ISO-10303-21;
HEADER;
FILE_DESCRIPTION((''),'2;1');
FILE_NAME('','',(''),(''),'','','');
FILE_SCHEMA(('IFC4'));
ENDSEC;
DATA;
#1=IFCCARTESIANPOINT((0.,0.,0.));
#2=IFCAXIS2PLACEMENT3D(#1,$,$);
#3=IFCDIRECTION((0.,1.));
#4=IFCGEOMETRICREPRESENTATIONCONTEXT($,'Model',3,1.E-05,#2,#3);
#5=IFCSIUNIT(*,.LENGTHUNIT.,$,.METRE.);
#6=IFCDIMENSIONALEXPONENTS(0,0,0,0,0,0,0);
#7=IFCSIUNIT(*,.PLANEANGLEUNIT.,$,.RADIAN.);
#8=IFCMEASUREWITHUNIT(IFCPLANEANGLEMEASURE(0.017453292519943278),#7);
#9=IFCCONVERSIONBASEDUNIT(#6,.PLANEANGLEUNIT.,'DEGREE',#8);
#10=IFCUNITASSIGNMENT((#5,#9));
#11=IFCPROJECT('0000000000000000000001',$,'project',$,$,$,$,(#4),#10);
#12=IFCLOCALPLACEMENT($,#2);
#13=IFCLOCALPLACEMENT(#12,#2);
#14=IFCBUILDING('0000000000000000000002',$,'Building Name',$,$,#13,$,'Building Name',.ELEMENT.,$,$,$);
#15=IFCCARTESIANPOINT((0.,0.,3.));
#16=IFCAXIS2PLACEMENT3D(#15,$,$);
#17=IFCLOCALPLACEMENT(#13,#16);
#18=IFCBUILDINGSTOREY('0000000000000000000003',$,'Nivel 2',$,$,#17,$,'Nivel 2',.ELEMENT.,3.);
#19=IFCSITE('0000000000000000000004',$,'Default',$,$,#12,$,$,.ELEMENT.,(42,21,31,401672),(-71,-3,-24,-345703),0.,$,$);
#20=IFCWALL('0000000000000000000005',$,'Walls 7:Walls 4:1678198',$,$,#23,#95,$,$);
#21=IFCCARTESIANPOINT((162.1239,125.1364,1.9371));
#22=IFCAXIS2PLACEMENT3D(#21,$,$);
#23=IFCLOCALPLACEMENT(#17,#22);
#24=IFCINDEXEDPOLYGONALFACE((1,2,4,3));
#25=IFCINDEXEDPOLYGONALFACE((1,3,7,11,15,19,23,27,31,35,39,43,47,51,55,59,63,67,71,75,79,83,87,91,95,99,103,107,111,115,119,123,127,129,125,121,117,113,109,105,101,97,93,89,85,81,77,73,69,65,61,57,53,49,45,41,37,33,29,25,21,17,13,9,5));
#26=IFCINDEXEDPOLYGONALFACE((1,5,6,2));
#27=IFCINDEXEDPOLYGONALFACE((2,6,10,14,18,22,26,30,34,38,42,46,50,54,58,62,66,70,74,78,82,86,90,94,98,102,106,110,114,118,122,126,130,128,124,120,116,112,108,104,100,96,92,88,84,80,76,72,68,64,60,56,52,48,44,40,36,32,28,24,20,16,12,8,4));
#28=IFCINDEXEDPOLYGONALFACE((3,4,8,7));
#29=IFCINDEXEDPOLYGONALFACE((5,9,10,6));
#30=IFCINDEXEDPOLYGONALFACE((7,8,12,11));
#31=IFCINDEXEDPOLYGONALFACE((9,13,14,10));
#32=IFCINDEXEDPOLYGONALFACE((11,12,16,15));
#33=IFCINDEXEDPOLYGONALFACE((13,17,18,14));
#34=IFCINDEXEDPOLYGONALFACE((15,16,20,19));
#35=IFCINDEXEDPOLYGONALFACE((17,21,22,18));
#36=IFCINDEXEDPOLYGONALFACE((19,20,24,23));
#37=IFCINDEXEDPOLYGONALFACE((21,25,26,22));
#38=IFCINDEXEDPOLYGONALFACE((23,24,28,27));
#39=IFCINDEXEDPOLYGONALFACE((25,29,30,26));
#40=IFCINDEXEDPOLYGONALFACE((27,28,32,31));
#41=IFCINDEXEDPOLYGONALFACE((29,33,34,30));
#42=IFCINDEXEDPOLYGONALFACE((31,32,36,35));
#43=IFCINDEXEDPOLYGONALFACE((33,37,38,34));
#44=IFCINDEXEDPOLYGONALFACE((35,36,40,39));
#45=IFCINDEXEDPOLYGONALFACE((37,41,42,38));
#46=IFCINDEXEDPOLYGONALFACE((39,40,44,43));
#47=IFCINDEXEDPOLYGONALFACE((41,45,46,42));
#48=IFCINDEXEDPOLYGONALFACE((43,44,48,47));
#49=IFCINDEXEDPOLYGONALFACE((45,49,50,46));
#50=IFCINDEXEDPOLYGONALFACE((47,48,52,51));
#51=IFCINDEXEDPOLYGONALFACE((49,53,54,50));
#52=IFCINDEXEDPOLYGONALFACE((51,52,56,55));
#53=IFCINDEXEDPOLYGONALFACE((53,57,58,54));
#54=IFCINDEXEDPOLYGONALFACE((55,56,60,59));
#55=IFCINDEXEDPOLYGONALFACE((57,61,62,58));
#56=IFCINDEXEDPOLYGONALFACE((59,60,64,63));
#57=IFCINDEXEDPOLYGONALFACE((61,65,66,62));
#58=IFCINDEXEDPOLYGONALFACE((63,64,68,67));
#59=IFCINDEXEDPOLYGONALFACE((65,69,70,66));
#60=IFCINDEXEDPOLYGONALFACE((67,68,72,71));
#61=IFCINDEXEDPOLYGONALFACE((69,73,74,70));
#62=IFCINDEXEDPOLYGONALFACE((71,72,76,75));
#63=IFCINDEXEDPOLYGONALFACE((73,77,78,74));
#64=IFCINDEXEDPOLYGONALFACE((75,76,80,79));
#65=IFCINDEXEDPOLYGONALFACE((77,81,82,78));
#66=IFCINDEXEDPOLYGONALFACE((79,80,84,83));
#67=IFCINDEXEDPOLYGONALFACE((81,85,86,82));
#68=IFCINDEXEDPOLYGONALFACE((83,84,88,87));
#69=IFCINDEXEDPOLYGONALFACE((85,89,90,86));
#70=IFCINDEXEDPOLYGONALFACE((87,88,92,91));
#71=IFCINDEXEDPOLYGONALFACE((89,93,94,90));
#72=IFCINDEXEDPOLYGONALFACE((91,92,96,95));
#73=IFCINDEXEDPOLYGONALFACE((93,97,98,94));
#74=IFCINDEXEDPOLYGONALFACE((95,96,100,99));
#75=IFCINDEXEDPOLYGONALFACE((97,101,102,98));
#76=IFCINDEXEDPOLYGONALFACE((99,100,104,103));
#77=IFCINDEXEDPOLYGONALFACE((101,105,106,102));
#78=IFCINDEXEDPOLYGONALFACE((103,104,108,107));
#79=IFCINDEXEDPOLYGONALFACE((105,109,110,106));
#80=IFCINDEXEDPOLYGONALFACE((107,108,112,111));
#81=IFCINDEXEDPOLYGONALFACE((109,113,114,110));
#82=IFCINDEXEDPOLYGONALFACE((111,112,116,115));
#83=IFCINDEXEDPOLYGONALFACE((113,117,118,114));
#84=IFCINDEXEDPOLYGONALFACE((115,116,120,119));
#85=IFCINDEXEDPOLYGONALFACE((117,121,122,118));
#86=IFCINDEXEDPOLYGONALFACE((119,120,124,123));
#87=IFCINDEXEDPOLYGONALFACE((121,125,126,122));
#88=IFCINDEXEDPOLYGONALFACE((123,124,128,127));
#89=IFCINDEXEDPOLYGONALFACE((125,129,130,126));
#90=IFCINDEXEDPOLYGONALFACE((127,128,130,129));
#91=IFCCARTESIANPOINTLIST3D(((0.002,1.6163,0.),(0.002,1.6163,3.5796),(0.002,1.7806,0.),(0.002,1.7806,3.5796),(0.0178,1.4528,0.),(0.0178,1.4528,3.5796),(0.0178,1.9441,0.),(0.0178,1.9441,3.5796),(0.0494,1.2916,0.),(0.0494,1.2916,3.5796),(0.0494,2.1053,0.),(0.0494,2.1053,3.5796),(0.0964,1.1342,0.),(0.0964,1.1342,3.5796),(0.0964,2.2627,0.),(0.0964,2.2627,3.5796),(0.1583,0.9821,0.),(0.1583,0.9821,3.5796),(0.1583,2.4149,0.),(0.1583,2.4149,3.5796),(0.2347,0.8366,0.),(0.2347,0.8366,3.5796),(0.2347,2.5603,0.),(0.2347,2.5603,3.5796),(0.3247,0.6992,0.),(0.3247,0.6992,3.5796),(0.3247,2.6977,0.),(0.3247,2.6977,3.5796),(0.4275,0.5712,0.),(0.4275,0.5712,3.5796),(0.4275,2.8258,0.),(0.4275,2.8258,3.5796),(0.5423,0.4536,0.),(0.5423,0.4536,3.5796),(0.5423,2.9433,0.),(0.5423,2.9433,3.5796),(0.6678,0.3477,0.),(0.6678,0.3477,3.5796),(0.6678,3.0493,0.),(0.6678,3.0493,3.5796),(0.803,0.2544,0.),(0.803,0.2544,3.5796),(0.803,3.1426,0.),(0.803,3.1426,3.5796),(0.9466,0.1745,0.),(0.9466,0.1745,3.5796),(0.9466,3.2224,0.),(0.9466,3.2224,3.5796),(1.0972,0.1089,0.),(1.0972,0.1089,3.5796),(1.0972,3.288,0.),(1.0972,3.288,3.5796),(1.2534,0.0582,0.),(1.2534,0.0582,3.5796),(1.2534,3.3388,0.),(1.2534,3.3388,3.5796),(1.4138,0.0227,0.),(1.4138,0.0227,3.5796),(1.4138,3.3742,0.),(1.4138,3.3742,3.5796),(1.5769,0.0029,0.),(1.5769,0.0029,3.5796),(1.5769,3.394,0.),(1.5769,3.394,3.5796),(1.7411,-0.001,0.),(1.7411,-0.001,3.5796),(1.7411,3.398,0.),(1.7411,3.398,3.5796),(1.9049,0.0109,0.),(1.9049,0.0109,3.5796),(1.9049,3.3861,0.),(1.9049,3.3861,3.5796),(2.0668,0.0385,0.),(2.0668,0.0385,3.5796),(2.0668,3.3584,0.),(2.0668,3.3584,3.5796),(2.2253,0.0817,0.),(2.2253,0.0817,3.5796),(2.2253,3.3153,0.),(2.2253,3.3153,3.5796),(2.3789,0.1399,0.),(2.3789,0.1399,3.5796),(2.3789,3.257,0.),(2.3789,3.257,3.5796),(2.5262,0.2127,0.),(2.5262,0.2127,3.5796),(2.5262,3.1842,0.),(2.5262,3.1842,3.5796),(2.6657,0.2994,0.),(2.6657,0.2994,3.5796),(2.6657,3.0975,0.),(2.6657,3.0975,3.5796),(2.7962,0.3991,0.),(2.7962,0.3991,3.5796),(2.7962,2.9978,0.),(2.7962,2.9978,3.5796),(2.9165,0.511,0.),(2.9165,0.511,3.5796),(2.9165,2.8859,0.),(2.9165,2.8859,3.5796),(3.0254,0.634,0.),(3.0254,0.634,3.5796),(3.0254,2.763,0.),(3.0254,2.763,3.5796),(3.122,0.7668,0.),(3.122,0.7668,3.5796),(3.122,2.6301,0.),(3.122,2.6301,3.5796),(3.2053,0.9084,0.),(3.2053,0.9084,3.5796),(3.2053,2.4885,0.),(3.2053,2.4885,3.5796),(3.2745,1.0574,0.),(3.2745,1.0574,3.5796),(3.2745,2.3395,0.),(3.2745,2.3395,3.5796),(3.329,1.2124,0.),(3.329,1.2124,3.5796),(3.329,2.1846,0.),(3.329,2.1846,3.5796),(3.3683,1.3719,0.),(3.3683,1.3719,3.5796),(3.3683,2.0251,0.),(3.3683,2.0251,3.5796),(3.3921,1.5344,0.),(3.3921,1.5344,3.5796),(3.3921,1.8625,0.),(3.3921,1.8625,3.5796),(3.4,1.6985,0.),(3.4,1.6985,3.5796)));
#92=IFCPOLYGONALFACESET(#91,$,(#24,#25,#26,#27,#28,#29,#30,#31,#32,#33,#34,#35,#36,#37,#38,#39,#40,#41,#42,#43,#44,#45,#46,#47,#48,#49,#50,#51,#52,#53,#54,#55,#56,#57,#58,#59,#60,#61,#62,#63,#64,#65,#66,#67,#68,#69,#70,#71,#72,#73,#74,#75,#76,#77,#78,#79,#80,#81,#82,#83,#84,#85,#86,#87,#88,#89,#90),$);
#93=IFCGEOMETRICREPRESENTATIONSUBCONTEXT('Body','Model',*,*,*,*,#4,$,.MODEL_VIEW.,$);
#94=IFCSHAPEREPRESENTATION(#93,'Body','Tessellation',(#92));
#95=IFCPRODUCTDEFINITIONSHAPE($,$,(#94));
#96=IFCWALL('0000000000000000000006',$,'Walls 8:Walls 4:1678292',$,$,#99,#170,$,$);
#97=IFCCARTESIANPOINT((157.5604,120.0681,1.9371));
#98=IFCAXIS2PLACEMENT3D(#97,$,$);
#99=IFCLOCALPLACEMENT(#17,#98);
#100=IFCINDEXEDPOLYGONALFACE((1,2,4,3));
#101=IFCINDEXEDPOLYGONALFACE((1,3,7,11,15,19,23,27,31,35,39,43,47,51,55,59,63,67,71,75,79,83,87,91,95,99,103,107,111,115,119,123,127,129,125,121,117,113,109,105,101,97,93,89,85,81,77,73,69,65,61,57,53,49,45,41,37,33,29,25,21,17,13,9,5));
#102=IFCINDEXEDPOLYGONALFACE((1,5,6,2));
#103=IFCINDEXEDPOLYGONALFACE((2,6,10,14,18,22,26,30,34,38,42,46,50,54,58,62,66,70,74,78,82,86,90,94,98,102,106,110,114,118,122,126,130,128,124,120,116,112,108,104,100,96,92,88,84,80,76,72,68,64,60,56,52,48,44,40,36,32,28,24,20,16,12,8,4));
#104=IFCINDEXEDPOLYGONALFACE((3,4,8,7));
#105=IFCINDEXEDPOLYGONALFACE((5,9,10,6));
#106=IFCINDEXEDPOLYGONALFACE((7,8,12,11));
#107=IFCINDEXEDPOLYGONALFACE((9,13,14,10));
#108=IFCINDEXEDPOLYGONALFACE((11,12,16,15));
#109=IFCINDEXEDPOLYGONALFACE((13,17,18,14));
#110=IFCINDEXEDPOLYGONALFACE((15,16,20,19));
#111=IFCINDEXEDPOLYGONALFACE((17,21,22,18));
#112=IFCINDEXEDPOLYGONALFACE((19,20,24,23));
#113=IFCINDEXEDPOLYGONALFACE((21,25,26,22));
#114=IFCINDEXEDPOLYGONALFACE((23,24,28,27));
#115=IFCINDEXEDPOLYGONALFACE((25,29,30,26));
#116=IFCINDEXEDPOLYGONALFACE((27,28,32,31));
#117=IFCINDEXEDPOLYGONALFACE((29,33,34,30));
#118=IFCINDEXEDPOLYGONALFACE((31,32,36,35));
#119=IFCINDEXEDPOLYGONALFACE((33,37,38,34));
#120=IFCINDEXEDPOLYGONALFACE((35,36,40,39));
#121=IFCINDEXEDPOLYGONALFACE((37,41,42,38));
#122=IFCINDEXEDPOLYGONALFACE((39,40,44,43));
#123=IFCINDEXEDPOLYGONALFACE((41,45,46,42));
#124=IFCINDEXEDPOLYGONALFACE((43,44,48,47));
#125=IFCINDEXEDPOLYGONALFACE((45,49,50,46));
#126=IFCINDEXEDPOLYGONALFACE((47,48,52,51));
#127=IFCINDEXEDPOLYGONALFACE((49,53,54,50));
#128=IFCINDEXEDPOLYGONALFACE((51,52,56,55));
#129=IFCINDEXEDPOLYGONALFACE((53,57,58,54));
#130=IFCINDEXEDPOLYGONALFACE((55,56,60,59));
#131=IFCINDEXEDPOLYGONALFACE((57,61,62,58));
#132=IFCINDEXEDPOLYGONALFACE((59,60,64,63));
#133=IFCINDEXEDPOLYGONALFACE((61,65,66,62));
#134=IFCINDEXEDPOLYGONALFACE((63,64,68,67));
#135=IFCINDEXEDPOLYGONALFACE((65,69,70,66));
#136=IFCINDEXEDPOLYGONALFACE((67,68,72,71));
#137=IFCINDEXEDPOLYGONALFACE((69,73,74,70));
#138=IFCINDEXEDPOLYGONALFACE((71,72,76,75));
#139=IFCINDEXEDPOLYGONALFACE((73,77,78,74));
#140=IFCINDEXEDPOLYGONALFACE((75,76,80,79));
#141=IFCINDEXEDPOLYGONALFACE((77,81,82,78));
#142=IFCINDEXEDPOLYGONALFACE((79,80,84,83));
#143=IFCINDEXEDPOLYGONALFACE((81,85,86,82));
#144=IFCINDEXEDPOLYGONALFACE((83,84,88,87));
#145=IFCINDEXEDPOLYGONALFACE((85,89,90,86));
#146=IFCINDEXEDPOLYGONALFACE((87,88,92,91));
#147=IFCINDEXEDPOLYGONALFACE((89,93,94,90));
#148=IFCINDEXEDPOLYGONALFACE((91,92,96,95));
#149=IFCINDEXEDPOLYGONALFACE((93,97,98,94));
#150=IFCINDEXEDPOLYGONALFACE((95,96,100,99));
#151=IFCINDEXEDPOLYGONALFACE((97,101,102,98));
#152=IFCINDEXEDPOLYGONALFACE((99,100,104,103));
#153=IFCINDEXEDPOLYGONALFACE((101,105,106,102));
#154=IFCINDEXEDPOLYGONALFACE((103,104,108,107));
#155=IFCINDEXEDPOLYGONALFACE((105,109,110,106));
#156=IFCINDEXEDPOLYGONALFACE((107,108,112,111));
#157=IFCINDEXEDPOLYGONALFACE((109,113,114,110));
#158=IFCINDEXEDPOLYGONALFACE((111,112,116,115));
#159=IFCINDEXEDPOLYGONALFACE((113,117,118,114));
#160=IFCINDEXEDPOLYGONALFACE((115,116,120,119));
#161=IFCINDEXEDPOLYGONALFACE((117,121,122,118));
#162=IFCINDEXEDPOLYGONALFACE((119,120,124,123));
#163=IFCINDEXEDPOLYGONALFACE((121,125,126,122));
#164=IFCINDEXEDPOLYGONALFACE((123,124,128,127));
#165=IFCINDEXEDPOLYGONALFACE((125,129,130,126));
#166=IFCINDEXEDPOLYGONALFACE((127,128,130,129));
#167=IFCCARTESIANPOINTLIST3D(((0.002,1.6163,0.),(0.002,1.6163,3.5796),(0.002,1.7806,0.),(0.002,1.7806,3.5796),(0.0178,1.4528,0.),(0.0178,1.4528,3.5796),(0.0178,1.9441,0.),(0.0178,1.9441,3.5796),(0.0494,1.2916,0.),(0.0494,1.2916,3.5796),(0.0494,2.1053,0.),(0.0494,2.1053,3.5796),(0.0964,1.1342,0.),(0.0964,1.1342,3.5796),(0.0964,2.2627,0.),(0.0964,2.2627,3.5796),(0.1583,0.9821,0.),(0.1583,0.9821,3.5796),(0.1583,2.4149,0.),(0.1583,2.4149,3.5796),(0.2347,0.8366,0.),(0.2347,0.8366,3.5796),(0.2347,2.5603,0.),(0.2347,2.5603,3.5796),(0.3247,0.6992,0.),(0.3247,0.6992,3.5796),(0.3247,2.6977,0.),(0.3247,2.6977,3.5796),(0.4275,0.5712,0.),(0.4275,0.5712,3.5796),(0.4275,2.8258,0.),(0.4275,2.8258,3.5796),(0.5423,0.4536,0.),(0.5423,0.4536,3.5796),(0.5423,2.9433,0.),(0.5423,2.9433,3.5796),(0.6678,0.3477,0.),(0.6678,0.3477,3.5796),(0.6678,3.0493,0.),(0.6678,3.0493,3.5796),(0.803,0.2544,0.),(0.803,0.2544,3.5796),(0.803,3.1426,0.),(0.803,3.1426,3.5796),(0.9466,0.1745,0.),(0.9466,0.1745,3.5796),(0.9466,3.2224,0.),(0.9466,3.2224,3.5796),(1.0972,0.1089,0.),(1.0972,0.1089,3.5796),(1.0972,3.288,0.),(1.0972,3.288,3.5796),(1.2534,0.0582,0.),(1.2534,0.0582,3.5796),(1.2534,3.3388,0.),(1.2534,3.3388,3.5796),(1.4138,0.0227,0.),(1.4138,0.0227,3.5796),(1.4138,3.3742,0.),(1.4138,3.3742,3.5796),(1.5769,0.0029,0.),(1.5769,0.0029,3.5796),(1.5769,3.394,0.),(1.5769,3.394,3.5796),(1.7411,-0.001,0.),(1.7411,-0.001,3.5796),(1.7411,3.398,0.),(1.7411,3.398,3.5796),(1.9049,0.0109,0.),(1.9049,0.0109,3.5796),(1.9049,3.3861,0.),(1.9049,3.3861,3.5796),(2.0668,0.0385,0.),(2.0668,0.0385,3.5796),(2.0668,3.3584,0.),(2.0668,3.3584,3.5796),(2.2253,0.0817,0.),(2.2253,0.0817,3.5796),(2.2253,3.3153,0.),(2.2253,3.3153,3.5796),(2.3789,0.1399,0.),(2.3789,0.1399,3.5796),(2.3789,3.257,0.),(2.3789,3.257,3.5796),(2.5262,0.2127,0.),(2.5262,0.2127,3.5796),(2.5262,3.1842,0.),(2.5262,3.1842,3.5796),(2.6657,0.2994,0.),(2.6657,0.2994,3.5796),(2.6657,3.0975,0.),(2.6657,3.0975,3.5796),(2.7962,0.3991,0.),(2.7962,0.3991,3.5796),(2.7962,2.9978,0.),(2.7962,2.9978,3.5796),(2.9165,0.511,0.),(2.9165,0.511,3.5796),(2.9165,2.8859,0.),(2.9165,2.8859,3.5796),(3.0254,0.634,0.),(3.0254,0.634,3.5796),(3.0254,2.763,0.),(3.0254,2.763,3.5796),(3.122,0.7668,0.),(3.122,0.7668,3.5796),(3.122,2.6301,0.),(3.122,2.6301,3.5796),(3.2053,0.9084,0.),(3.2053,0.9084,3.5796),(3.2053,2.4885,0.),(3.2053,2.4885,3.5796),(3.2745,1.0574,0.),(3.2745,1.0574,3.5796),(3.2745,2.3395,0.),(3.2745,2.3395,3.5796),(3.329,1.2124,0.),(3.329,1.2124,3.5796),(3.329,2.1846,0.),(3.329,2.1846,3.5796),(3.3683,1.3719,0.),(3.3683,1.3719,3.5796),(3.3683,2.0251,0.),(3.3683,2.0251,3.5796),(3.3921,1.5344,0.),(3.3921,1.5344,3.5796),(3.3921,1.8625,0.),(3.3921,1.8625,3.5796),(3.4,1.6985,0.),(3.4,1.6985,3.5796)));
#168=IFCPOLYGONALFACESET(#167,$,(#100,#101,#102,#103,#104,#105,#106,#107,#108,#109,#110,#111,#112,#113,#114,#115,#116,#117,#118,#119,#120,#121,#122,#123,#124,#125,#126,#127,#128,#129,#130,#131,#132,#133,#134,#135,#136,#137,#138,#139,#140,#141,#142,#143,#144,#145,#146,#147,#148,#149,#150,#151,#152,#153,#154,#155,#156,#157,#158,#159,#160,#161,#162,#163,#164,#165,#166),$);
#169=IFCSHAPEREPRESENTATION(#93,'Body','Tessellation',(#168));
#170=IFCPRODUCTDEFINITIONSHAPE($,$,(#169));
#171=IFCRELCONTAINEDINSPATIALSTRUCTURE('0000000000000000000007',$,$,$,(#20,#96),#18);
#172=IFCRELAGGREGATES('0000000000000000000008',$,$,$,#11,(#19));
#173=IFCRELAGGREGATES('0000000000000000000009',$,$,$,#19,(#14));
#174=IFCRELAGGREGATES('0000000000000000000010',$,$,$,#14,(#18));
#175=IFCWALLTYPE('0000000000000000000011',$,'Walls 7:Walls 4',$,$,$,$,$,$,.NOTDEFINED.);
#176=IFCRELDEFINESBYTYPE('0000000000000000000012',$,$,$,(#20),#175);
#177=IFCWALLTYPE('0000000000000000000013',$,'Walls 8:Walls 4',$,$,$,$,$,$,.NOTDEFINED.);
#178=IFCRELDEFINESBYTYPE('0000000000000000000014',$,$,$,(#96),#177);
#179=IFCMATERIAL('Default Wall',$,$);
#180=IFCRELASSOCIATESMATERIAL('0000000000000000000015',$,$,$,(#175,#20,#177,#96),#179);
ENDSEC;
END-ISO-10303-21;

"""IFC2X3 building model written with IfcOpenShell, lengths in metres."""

from ifc_helpers import new_model, entity, si_unit, converted_unit, direction, frame, origin, origin_2d_with_axis, place, context, subcontext, project, spatial, circle, extrude, material, type_object, element, save


model = new_model("IFC2X3")

# Units and contexts
model_context = context("Model", 3, precision=1e-05, world=origin(), true_north=direction((0.0, 1.0)))
body_context = subcontext(model_context, "Body", "Model", "MODEL_VIEW")
ifc_project = project(units=[si_unit("LENGTHUNIT", "METRE"), converted_unit("PLANEANGLEUNIT", "DEGREE", entity("IfcPlaneAngleMeasure", 0.017453292519943278), si_unit("PLANEANGLEUNIT", "RADIAN"), dimensions=[0, 0, 0, 0, 0, 0, 0])], contexts=[model_context])

# Site, building, storey
site_placement = place(None, origin())
site = spatial("IfcSite", under=ifc_project, at=site_placement, Name="Default", CompositionType="ELEMENT", RefLatitude=(42, 21, 31, 401672), RefLongitude=(-71, -3, -24, -345703), RefElevation=0.0)
building_placement = place(site_placement, origin())
building = spatial("IfcBuilding", under=site, at=building_placement, Name="Building Name", LongName="Building Name", CompositionType="ELEMENT")
storey_placement = place(building_placement, frame((0.0, 0.0, 3.0)))
storey = spatial("IfcBuildingStorey", under=building, at=storey_placement, Name="Nivel 2", LongName="Nivel 2", CompositionType="ELEMENT", Elevation=3.0)

# Walls
ifc_material_1 = material(Name="Default Wall")
wall_type_1 = type_object("IfcWallType", Name="Walls 7:Walls 4", PredefinedType="NOTDEFINED", material=ifc_material_1)
wall_1_placement = place(storey_placement, frame((162.1239, 125.1364, 1.9371)))
element("IfcWall", 1, at=wall_1_placement, inside=storey, type_object=wall_type_1, material=ifc_material_1, Name="Walls 7:Walls 4:1678198", context=body_context, shape_type="SweptSolid", body=[
    extrude(circle(Radius=1.7, at=origin_2d_with_axis()), frame((1.7, 1.6985, 0.0)), (0.0, 0.0, 1.0), 3.5796),
])
wall_type_2 = type_object("IfcWallType", Name="Walls 8:Walls 4", PredefinedType="NOTDEFINED", material=ifc_material_1)
wall_2_placement = place(storey_placement, frame((157.5604, 120.0681, 1.9371)))
element("IfcWall", 2, at=wall_2_placement, inside=storey, type_object=wall_type_2, material=ifc_material_1, Name="Walls 8:Walls 4:1678292", context=body_context, shape_type="SweptSolid", body=[
    extrude(circle(Radius=1.7, at=origin_2d_with_axis()), frame((1.7, 1.6985, 0.0)), (0.0, 0.0, 1.0), 3.5796),
])

save(model, "model.ifc")
